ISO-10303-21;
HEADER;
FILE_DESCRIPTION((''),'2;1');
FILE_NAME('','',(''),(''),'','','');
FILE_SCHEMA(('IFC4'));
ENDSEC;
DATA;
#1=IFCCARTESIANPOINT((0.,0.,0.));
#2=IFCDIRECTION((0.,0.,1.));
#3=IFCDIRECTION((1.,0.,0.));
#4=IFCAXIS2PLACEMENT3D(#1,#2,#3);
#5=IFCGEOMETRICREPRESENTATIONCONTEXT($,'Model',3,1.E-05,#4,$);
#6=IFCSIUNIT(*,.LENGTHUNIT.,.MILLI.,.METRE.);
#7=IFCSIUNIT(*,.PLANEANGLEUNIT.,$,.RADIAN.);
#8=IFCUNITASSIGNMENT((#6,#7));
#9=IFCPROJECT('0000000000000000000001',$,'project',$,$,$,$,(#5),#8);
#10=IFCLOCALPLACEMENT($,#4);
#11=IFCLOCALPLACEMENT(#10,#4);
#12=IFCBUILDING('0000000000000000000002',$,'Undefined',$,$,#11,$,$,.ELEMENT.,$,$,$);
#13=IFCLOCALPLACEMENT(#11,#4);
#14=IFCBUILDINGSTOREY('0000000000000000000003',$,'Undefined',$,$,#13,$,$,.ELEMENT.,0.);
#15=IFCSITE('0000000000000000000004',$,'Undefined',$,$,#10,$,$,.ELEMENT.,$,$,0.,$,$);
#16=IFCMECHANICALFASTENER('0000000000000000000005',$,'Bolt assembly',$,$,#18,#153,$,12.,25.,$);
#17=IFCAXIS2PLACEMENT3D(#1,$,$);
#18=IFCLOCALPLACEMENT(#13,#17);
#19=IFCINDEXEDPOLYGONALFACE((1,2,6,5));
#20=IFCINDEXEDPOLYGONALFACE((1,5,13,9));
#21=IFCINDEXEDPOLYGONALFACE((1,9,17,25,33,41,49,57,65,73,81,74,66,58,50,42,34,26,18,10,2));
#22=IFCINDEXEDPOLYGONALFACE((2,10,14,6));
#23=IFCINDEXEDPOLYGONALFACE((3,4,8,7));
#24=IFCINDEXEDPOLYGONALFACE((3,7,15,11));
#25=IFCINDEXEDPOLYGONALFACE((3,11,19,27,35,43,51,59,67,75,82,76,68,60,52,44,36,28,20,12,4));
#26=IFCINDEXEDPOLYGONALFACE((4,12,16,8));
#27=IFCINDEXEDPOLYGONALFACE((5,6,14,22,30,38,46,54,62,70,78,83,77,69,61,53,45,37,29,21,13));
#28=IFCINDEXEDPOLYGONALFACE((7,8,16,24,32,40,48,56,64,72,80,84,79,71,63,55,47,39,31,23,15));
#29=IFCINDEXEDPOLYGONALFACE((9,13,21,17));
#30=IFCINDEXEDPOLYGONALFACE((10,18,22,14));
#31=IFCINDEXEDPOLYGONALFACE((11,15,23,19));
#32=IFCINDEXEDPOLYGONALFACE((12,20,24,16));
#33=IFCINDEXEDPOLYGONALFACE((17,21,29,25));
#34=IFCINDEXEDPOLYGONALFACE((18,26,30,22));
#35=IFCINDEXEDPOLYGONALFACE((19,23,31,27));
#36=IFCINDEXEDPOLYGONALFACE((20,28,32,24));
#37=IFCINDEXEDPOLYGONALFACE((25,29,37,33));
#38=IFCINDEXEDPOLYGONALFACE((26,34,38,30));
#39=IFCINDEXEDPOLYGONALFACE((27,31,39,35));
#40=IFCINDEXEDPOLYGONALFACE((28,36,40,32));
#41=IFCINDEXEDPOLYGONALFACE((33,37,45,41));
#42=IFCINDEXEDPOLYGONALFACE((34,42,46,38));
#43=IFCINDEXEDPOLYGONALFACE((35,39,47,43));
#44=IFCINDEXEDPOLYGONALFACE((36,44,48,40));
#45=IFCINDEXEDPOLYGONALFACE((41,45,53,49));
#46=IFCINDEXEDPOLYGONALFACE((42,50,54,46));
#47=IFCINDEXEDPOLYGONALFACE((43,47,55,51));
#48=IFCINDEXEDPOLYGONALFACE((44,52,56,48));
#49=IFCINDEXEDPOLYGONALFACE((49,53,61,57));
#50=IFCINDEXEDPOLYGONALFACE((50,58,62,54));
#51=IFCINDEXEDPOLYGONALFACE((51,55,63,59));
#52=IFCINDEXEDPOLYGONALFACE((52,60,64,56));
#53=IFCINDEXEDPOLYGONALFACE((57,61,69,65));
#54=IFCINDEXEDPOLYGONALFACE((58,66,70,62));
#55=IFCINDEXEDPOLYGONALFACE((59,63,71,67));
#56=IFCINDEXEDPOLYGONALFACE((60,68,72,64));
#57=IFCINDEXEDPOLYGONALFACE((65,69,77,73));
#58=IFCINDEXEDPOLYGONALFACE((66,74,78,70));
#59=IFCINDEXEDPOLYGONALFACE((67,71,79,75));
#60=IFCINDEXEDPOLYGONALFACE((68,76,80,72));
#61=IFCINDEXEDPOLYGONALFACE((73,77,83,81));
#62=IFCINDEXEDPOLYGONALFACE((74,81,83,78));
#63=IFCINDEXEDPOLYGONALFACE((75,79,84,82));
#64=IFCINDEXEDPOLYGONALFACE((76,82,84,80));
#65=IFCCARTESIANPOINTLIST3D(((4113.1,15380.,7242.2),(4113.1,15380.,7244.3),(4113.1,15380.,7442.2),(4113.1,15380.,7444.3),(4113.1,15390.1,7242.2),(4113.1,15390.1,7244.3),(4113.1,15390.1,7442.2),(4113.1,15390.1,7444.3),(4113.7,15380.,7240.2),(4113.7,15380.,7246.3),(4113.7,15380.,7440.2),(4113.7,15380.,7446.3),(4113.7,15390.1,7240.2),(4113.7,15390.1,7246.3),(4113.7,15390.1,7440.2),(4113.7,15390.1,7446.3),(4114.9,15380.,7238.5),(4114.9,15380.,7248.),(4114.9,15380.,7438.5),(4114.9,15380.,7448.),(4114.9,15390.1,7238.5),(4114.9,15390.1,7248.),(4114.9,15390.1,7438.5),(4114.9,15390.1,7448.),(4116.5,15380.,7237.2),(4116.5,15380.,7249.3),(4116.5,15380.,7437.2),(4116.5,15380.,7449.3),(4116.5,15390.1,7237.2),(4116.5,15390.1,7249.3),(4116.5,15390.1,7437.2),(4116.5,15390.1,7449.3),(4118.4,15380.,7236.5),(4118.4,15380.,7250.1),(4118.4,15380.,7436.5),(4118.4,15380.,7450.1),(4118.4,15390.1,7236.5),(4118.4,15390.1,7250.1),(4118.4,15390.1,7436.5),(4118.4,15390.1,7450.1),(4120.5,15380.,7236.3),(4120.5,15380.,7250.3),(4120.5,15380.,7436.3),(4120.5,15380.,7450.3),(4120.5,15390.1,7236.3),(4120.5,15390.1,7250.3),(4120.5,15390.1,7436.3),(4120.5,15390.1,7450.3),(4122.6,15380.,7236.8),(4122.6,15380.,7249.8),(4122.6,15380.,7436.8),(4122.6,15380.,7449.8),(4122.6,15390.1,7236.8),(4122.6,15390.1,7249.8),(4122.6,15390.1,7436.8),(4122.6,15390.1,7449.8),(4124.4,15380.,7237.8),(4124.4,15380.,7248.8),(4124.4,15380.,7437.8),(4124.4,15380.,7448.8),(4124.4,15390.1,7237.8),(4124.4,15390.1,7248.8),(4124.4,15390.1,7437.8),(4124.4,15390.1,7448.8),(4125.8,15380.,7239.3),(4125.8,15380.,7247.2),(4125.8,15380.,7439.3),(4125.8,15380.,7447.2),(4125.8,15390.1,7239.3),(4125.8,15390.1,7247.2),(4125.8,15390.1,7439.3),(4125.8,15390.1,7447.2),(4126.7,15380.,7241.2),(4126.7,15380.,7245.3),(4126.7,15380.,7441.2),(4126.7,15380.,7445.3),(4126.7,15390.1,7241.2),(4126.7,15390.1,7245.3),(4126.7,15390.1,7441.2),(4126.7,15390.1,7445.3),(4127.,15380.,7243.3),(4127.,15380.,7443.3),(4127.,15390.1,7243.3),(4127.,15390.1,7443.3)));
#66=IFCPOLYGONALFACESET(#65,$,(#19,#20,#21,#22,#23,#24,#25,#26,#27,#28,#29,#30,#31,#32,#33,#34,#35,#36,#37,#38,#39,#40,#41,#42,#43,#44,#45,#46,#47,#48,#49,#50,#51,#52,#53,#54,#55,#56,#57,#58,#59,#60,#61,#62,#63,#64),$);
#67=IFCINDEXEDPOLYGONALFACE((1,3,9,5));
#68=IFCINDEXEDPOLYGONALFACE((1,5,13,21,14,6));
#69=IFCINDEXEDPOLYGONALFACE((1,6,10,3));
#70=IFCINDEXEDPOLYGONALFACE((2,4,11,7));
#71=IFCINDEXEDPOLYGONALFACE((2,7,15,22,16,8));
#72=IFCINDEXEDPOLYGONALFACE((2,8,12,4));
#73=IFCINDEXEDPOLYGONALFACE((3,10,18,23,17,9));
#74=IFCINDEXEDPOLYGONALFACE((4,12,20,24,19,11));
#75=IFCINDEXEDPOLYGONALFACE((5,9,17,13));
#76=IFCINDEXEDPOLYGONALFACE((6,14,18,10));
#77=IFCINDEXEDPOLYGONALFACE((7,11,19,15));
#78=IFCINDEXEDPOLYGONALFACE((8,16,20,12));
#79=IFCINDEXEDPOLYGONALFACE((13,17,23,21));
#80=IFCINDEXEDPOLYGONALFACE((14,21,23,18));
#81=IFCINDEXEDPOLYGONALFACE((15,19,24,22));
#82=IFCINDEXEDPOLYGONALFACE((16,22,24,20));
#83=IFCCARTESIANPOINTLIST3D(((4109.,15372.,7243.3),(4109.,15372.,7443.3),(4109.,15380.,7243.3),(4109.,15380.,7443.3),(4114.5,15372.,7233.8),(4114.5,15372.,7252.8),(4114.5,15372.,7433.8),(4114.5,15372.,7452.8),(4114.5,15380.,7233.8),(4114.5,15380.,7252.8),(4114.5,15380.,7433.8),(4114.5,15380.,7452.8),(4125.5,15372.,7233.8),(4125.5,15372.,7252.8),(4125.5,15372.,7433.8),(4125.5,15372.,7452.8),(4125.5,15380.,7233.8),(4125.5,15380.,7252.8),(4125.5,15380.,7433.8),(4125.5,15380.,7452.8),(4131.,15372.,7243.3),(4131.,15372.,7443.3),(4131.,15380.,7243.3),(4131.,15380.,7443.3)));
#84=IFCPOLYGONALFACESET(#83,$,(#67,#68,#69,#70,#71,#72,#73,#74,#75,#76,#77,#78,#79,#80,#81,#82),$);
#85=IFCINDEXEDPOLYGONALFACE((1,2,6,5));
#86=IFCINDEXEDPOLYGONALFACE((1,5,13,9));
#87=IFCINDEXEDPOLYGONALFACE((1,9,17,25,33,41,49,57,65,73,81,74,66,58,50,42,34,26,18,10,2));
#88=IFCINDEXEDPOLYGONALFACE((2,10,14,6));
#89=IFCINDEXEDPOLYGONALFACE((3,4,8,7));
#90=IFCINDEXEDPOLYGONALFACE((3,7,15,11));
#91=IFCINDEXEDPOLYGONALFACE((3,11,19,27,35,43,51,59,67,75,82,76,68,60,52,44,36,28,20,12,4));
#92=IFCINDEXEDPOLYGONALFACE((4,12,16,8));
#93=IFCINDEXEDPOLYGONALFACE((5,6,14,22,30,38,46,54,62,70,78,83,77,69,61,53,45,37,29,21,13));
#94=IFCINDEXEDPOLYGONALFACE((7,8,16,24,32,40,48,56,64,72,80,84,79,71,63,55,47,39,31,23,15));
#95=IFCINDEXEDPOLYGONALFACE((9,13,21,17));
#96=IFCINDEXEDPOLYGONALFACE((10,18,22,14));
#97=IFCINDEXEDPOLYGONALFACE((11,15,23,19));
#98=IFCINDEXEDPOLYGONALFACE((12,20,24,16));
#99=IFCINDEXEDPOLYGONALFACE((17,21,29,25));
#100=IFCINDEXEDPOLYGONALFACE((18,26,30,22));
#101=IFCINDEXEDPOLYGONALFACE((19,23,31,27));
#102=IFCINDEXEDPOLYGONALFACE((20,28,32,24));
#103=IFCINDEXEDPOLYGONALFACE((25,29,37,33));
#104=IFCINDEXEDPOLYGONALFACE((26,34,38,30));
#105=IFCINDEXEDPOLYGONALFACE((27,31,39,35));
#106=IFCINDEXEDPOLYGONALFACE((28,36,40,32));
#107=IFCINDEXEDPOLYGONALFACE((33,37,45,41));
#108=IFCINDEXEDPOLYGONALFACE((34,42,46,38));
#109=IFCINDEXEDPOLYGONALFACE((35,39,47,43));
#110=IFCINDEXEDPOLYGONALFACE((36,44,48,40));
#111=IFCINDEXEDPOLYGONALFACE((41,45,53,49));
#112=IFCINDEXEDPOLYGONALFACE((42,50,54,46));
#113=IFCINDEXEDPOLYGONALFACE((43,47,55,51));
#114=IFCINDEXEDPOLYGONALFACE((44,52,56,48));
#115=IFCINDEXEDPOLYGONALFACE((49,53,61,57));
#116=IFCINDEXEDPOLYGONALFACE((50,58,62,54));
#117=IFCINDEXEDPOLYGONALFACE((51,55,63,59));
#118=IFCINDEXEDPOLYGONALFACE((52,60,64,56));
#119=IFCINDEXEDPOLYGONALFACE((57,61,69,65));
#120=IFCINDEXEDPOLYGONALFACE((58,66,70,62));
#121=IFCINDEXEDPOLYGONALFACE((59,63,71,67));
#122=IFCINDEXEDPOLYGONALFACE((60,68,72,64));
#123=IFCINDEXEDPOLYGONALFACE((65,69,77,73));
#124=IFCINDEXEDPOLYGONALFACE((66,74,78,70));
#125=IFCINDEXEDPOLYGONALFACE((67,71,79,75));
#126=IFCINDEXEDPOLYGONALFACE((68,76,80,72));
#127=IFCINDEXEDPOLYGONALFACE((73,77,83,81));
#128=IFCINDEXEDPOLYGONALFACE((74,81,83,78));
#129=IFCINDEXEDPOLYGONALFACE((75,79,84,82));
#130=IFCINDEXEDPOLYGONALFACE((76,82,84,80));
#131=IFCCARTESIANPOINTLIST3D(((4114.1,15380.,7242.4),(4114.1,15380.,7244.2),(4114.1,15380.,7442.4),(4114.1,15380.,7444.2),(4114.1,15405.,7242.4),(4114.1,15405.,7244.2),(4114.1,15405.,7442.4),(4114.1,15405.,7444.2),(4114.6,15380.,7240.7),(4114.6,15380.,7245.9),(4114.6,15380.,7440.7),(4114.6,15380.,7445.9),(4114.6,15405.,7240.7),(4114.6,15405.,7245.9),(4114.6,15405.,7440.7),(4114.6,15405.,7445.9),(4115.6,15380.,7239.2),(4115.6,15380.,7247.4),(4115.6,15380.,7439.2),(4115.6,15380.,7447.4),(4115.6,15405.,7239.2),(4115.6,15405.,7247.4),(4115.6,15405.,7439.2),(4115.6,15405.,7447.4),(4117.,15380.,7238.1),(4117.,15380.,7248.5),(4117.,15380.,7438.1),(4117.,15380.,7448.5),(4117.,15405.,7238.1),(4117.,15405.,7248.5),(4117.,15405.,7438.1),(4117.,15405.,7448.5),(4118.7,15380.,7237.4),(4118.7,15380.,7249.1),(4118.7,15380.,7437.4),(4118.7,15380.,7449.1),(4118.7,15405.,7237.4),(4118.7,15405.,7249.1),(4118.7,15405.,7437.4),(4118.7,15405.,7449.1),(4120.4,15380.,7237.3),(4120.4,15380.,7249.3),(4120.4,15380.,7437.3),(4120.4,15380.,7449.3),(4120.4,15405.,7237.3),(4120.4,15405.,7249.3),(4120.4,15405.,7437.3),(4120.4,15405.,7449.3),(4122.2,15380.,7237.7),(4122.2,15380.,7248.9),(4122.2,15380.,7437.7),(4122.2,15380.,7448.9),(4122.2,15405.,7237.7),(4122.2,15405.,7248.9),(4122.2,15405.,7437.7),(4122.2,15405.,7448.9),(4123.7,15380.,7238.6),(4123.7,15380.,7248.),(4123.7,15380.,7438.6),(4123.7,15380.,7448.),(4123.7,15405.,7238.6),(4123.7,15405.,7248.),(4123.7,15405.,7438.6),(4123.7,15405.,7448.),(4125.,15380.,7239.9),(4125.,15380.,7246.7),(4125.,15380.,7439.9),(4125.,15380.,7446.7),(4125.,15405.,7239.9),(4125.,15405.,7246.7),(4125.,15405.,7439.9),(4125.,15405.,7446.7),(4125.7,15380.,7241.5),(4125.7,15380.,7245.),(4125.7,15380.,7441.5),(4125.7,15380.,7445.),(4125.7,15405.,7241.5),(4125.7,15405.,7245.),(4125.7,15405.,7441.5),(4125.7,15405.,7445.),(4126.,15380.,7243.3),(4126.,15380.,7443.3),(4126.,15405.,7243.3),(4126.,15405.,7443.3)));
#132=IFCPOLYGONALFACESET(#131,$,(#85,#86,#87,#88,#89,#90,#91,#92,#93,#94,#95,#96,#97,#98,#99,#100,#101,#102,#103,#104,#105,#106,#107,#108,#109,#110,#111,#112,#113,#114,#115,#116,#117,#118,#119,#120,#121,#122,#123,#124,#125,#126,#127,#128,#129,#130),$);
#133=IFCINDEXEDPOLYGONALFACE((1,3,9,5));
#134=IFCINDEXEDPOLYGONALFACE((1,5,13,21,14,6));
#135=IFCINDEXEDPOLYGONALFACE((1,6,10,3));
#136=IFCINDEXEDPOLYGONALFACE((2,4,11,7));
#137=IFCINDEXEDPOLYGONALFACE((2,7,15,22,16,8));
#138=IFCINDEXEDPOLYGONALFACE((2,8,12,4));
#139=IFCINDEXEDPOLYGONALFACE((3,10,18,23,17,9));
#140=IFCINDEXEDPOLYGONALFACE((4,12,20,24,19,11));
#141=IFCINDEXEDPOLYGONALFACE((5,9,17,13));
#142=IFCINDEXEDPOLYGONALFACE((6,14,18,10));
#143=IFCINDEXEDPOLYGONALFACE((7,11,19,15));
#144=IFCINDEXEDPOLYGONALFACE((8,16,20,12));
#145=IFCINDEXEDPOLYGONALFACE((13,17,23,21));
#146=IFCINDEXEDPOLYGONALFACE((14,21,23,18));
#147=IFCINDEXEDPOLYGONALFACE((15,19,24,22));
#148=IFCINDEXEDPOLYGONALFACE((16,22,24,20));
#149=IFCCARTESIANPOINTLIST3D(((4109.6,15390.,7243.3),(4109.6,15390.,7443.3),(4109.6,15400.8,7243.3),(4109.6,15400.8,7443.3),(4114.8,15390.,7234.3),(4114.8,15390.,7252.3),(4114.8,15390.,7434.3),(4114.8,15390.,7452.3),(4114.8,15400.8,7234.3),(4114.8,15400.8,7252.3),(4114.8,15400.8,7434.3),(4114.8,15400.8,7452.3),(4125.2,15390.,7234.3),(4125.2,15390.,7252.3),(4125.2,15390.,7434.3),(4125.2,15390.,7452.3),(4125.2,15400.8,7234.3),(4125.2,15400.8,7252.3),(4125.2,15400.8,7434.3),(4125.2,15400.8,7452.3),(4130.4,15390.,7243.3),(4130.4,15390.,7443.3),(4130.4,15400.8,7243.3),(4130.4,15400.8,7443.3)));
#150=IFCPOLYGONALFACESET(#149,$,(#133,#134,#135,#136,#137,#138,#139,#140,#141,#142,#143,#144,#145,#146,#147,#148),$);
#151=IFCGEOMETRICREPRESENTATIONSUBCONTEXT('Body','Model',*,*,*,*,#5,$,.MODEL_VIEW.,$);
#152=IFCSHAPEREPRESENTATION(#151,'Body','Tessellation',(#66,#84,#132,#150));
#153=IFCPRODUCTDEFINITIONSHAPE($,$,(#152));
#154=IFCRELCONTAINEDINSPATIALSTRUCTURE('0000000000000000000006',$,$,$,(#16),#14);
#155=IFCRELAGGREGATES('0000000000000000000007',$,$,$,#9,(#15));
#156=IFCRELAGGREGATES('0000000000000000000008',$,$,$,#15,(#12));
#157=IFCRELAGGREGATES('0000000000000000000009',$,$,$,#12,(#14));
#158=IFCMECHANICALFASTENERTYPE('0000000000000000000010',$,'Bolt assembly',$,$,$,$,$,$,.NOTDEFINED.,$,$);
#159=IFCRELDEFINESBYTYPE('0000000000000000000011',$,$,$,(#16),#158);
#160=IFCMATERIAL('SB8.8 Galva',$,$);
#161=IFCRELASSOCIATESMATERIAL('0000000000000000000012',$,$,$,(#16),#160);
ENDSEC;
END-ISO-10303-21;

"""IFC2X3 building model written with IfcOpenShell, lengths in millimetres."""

from ifc_helpers import new_model, si_unit, frame, origin_with_axes, origin_2d_with_axis, place, context, subcontext, project, spatial, polyline, circle, outline, extrude, source, transform, mapped, material, type_object, element, save


model = new_model("IFC2X3")

# Units and contexts
model_context = context("Model", 3, precision=1e-05, world=origin_with_axes())
body_context = subcontext(model_context, "Body", "Model", "MODEL_VIEW")
ifc_project = project(units=[si_unit("LENGTHUNIT", "METRE", prefix="MILLI"), si_unit("PLANEANGLEUNIT", "RADIAN")], contexts=[model_context])

# Site, building, storey
site_placement = place(None, origin_with_axes())
site = spatial("IfcSite", under=ifc_project, at=site_placement, Name="Undefined", CompositionType="ELEMENT", RefElevation=0.0)
building_placement = place(site_placement, origin_with_axes())
building = spatial("IfcBuilding", under=site, at=building_placement, Name="Undefined", CompositionType="ELEMENT")
storey_placement = place(building_placement, origin_with_axes())
storey = spatial("IfcBuildingStorey", under=building, at=storey_placement, Name="Undefined", CompositionType="ELEMENT", Elevation=0.0)

# Mechanical fastener
mechanical_fastener_type = type_object("IfcMechanicalFastenerType", Name="Bolt assembly")
ifc_material_1 = material(Name="SB8.8 Galva")
shared_shape_1 = source(origin_with_axes(), body_context, "Body", "SweptSolid", [
    extrude(circle(Radius=7.0, at=origin_2d_with_axis()), frame((0.0, -10.0, 0.0), z_axis=(0.0, 1.0, 0.0), x_axis=(1.0, 0.0, 0.0)), (0.0, 0.0, 1.0), 10.1),
    extrude(outline(polyline([(11.0, 0.0), (5.5, 9.5), (-5.5, 9.5), (-11.0, 0.0), (-5.5, -9.5), (5.5, -9.5), (11.0, 0.0)])), frame((0.0, -18.0, 0.0), z_axis=(0.0, 1.0, 0.0), x_axis=(1.0, 0.0, 0.0)), (0.0, 0.0, 1.0), 8.0),
    extrude(circle(Radius=6.0, at=origin_2d_with_axis()), frame((0.0, -10.0, 0.0), z_axis=(0.0, 1.0, 0.0), x_axis=(1.0, 0.0, 0.0)), (0.0, 0.0, 1.0), 25.0),
    extrude(outline(polyline([(10.4, 0.0), (5.2, 9.0), (-5.2, 9.0), (-10.4, 0.0), (-5.2, -9.0), (5.2, -9.0), (10.4, 0.0)])), frame((0.0, 0.0, 0.0), z_axis=(0.0, 1.0, 0.0), x_axis=(1.0, 0.0, 0.0)), (0.0, 0.0, 1.0), 10.8),
])
for number, where, z_axis, x_axis, name in (
    (1, (4120.0, 15390.0, 7343.3), (0.0, 0.0, 1.0), (1.0, 0.0, 0.0), "Bolt assembly"),
):
    element("IfcMechanicalFastener", number, at=place(storey_placement, frame(where, z_axis=z_axis, x_axis=x_axis)), inside=storey, type_object=mechanical_fastener_type, material=ifc_material_1, Name=name, NominalDiameter=12.0, NominalLength=25.0, context=body_context, shape_type="MappedRepresentation", body=[
        mapped(shared_shape_1, transform((0.0, 0.0, -100.0))),
        mapped(shared_shape_1, transform((0.0, 0.0, 100.0))),
    ])

save(model, "model.ifc")
